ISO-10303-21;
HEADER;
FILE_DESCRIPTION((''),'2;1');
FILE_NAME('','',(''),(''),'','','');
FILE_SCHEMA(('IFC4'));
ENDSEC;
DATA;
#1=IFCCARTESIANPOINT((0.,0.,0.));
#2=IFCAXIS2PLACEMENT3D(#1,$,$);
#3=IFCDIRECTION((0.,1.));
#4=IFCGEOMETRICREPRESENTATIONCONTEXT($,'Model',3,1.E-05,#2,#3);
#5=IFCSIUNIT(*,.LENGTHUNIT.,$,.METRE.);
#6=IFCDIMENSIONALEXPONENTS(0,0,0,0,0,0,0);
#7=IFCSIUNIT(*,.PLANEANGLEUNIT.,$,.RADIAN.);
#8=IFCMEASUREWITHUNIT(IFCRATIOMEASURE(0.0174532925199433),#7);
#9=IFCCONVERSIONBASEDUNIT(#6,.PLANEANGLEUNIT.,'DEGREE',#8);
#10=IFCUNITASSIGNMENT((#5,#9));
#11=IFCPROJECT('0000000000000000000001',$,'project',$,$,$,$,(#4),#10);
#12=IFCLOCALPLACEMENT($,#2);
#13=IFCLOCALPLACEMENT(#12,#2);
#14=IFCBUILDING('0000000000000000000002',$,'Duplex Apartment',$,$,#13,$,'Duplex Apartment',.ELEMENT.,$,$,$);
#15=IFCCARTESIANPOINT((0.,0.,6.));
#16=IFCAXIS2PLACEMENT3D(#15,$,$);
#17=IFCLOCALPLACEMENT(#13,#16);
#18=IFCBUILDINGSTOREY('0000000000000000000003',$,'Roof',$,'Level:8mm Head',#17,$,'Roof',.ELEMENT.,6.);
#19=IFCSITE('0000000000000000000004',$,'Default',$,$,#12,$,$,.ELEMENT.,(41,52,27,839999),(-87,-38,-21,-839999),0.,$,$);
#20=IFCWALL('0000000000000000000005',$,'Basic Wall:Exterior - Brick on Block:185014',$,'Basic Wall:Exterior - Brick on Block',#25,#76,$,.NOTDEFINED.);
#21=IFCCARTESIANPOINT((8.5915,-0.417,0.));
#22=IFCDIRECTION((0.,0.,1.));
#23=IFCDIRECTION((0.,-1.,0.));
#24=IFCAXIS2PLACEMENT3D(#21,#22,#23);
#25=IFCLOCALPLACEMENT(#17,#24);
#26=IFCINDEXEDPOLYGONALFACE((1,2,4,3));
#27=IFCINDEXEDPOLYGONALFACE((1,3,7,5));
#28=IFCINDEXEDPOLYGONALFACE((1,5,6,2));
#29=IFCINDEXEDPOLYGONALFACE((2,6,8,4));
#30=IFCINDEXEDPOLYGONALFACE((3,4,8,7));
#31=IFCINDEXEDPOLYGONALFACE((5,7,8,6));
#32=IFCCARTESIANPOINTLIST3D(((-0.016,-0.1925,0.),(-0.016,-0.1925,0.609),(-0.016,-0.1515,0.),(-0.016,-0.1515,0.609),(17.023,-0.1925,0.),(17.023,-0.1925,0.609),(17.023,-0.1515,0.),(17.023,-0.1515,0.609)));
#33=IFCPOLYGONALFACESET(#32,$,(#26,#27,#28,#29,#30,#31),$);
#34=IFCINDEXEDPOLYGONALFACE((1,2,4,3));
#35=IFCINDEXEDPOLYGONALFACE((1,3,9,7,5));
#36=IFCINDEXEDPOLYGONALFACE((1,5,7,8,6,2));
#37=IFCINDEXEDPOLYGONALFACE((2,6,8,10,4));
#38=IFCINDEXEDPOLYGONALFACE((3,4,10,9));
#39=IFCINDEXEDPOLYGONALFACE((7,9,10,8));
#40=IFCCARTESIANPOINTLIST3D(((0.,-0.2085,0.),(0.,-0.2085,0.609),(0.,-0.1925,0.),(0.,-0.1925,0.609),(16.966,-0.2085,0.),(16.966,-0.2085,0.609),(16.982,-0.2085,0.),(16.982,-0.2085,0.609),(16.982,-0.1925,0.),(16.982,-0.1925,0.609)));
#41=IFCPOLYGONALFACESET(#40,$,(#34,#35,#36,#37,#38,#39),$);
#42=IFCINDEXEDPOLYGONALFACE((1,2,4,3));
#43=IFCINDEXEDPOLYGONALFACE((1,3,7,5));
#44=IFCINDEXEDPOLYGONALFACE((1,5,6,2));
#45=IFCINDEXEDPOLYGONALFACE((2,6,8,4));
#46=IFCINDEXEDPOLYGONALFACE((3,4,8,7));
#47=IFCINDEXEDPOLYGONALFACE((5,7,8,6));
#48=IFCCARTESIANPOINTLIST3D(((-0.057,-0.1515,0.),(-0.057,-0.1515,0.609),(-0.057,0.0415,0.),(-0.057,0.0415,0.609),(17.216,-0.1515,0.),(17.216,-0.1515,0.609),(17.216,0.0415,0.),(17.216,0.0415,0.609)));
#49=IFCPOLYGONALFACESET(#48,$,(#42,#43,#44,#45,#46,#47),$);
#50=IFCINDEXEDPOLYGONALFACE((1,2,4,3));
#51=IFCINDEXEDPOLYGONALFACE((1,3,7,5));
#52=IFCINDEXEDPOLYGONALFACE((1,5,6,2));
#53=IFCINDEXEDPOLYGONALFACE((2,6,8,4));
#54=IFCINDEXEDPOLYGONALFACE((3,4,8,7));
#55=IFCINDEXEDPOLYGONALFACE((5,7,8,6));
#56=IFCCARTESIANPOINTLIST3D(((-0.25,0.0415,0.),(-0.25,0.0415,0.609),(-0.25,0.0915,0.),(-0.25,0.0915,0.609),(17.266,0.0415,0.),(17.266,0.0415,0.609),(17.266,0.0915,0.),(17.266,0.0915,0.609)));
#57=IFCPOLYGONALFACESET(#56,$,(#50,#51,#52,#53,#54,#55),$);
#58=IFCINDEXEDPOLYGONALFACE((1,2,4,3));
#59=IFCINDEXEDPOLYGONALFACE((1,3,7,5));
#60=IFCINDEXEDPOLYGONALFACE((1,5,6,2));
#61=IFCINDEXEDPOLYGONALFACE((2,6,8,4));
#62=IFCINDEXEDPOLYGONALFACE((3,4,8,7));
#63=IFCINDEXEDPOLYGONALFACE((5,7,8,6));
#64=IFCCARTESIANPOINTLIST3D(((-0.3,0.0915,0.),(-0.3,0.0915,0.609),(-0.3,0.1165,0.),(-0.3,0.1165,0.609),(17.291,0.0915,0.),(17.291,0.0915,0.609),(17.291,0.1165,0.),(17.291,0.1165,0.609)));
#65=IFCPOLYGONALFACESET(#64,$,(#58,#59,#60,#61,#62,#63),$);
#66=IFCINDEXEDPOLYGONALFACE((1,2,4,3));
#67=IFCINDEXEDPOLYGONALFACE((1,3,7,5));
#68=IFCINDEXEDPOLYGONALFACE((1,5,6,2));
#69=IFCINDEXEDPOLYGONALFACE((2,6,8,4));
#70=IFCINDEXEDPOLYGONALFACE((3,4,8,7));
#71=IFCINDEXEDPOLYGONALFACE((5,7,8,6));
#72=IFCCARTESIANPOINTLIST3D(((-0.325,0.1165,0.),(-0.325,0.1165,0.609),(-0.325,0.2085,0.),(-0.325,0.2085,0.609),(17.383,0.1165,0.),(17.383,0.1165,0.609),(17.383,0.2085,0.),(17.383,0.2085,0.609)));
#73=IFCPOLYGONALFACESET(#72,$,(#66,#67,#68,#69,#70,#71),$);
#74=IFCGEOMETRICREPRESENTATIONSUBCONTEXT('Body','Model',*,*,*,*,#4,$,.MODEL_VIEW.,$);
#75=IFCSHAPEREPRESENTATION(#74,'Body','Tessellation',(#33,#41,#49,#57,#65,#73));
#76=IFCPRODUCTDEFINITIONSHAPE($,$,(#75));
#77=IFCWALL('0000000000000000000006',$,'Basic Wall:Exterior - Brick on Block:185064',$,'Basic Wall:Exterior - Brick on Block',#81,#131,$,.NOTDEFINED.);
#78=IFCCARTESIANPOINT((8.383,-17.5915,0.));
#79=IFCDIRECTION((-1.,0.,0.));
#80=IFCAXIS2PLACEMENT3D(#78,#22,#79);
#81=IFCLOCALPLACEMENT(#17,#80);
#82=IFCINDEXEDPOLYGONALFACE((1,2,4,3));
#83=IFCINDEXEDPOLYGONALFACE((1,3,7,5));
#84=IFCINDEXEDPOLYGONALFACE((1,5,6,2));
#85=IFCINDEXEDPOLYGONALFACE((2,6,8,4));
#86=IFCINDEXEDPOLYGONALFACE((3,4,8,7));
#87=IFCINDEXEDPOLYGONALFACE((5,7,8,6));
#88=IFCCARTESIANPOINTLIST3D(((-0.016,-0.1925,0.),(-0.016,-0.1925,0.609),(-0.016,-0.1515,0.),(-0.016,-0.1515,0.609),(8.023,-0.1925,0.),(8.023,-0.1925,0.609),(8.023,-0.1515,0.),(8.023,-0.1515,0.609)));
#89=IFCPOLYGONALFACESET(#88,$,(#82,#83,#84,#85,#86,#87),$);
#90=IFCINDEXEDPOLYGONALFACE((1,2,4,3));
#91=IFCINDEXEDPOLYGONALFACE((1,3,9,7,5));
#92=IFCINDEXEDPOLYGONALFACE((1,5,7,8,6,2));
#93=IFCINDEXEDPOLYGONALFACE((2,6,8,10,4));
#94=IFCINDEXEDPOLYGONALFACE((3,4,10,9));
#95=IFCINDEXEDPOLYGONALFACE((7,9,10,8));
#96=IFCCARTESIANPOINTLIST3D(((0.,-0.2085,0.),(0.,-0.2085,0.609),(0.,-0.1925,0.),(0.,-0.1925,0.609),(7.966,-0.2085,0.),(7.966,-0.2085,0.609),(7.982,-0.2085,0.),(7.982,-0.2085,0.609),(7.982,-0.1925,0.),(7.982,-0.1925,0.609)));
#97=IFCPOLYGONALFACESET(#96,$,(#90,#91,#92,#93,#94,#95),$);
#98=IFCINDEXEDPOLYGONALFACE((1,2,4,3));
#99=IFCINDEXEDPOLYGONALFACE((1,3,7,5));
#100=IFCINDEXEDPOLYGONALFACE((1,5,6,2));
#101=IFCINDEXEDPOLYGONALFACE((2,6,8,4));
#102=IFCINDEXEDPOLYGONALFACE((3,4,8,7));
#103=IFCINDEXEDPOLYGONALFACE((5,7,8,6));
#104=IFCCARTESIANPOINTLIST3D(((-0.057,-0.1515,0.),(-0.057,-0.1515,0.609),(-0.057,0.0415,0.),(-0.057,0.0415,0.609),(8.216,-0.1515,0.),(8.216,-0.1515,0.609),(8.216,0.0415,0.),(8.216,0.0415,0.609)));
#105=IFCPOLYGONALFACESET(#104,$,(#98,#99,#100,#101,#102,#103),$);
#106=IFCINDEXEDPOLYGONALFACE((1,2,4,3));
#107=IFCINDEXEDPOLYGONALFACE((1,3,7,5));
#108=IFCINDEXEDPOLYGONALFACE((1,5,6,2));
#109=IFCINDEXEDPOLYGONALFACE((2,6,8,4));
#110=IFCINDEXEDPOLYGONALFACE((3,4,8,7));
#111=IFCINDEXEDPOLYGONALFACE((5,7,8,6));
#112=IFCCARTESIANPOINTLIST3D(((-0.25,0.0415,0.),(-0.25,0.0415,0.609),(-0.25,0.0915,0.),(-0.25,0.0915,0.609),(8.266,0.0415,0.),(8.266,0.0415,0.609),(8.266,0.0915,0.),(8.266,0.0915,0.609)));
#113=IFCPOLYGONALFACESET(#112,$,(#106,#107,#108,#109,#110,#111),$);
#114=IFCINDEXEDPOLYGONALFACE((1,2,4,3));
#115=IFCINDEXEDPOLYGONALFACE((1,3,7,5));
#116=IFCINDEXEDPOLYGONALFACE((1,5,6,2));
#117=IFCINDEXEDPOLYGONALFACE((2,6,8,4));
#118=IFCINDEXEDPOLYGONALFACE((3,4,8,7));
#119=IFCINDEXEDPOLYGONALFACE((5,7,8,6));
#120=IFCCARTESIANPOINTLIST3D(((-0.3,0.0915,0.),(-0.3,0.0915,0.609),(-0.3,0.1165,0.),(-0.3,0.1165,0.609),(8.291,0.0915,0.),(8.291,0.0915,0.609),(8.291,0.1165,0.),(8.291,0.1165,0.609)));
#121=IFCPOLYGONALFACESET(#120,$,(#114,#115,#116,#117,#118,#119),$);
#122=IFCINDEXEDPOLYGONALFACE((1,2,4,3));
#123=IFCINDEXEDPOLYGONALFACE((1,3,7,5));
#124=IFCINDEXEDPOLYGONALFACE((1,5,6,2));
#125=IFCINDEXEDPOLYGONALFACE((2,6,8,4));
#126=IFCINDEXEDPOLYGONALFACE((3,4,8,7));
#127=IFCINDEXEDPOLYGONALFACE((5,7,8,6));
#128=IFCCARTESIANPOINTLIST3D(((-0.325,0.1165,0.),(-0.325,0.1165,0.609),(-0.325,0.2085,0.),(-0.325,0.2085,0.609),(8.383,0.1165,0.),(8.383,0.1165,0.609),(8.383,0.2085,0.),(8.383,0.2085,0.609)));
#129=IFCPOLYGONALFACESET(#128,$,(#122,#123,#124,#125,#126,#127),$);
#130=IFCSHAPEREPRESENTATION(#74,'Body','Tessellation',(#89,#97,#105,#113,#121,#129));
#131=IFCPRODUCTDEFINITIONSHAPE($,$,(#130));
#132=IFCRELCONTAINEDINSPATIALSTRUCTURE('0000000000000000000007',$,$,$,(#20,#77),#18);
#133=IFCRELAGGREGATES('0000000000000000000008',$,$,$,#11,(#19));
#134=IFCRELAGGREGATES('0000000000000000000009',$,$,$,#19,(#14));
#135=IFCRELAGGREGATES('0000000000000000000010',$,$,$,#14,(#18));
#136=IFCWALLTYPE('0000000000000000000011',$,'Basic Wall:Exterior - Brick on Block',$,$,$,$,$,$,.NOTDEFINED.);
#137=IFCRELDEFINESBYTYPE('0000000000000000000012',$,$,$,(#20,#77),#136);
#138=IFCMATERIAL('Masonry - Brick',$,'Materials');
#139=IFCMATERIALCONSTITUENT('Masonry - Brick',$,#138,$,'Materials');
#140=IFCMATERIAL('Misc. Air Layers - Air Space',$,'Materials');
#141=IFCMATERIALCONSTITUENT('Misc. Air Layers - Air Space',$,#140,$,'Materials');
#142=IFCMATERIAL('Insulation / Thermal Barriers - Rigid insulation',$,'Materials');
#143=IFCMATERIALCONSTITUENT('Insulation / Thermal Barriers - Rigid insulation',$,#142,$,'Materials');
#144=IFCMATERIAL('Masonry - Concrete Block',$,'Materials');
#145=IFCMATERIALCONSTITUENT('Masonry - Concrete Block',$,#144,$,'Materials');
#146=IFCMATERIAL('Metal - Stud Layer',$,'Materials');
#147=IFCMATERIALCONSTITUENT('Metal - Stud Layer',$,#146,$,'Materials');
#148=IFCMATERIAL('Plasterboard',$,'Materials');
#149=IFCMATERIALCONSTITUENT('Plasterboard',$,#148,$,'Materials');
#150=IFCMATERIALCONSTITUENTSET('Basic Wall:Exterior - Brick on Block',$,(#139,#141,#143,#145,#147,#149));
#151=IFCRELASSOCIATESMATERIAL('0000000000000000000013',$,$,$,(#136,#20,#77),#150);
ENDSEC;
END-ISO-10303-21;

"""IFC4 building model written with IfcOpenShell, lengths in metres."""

from ifc_helpers import new_model, entity, si_unit, converted_unit, direction, frame, origin, place, context, subcontext, project, spatial, indexed_curve, outline, extrude, material, constituent, constituent_set, type_object, element, save


model = new_model("IFC4")

# Units and contexts
model_context = context("Model", 3, precision=1e-05, world=origin(), true_north=direction((0.0, 1.0)))
body_context = subcontext(model_context, "Body", "Model", "MODEL_VIEW")
ifc_project = project(units=[si_unit("LENGTHUNIT", "METRE"), converted_unit("PLANEANGLEUNIT", "DEGREE", entity("IfcRatioMeasure", 0.0174532925199433), si_unit("PLANEANGLEUNIT", "RADIAN"), dimensions=[0, 0, 0, 0, 0, 0, 0])], contexts=[model_context])

# Site, building, storey
site_placement = place(None, origin())
site = spatial("IfcSite", under=ifc_project, at=site_placement, Name="Default", CompositionType="ELEMENT", RefLatitude=(41, 52, 27, 839999), RefLongitude=(-87, -38, -21, -839999), RefElevation=0.0)
building_placement = place(site_placement, origin())
building = spatial("IfcBuilding", under=site, at=building_placement, Name="Duplex Apartment", LongName="Duplex Apartment", CompositionType="ELEMENT")
storey_placement = place(building_placement, frame((0.0, 0.0, 6.0)))
storey = spatial("IfcBuildingStorey", under=building, at=storey_placement, Name="Roof", ObjectType="Level:8mm Head", LongName="Roof", CompositionType="ELEMENT", Elevation=6.0)

# Shared definitions
ifc_material_1 = material(Name="Insulation / Thermal Barriers - Rigid insulation", Category="Materials")

# Walls
ifc_material_2 = material(Name="Masonry - Brick", Category="Materials")
ifc_constituent_1 = constituent(ifc_material_2, Name="Masonry - Brick", Category="Materials")
ifc_material_3 = material(Name="Misc. Air Layers - Air Space", Category="Materials")
ifc_constituent_2 = constituent(ifc_material_3, Name="Misc. Air Layers - Air Space", Category="Materials")
ifc_constituent_3 = constituent(ifc_material_1, Name="Insulation / Thermal Barriers - Rigid insulation", Category="Materials")
ifc_material_4 = material(Name="Masonry - Concrete Block", Category="Materials")
ifc_constituent_4 = constituent(ifc_material_4, Name="Masonry - Concrete Block", Category="Materials")
ifc_material_5 = material(Name="Metal - Stud Layer", Category="Materials")
ifc_constituent_5 = constituent(ifc_material_5, Name="Metal - Stud Layer", Category="Materials")
ifc_material_6 = material(Name="Plasterboard", Category="Materials")
ifc_constituent_6 = constituent(ifc_material_6, Name="Plasterboard", Category="Materials")
ifc_constituent_set_1 = constituent_set(constituents=[ifc_constituent_1, ifc_constituent_2, ifc_constituent_3, ifc_constituent_4, ifc_constituent_5, ifc_constituent_6], Name="Basic Wall:Exterior - Brick on Block")
wall_type = type_object("IfcWallType", Name="Basic Wall:Exterior - Brick on Block", PredefinedType="NOTDEFINED", material=ifc_constituent_set_1)
wall_1_placement = place(storey_placement, frame((8.5915, -0.417, 0.0), z_axis=(0.0, 0.0, 1.0), x_axis=(0.0, -1.0, 0.0)))
element("IfcWall", 1, at=wall_1_placement, inside=storey, type_object=wall_type, material=ifc_constituent_set_1, Name="Basic Wall:Exterior - Brick on Block:185014", ObjectType="Basic Wall:Exterior - Brick on Block", PredefinedType="NOTDEFINED", context=body_context, shape_type="SweptSolid", body=[
    extrude(outline(indexed_curve([(-8.5195, -0.0205), (8.5195, -0.0205), (8.5195, 0.0205), (-8.5195, 0.0205), (-8.5195, -0.0205)], self_intersect=False)), frame((8.5035, -0.172, 0.0)), (0.0, 0.0, 1.0), 0.609),
    extrude(outline(indexed_curve([(6.78, -0.0064), (6.796, -0.0064), (6.796, 0.0096), (-10.186, 0.0096), (-10.186, -0.0064), (6.78, -0.0064)], self_intersect=False)), frame((10.186, -0.2021, 0.0)), (0.0, 0.0, 1.0), 0.609),
    extrude(outline(indexed_curve([(-8.6365, -0.0965), (8.6365, -0.0965), (8.6365, 0.0965), (-8.6365, 0.0965), (-8.6365, -0.0965)], self_intersect=False)), frame((8.5795, -0.055, 0.0)), (0.0, 0.0, 1.0), 0.609),
    extrude(outline(indexed_curve([(-8.758, -0.025), (8.758, -0.025), (8.758, 0.025), (-8.758, 0.025), (-8.758, -0.025)], self_intersect=False)), frame((8.508, 0.0665, 0.0)), (0.0, 0.0, 1.0), 0.609),
    extrude(outline(indexed_curve([(-8.7955, -0.0125), (8.7955, -0.0125), (8.7955, 0.0125), (-8.7955, 0.0125), (-8.7955, -0.0125)], self_intersect=False)), frame((8.4955, 0.104, 0.0)), (0.0, 0.0, 1.0), 0.609),
    extrude(outline(indexed_curve([(-0.046, -8.854), (0.046, -8.854), (0.046, 8.854), (-0.046, 8.854), (-0.046, -8.854)], self_intersect=False)), frame((8.529, 0.1625, 0.0), z_axis=(0.0, 0.0, 1.0), x_axis=(0.0, -1.0, 0.0)), (0.0, 0.0, 1.0), 0.609),
])
wall_2_placement = place(storey_placement, frame((8.383, -17.5915, 0.0), z_axis=(0.0, 0.0, 1.0), x_axis=(-1.0, 0.0, 0.0)))
element("IfcWall", 2, at=wall_2_placement, inside=storey, type_object=wall_type, material=ifc_constituent_set_1, Name="Basic Wall:Exterior - Brick on Block:185064", ObjectType="Basic Wall:Exterior - Brick on Block", PredefinedType="NOTDEFINED", context=body_context, shape_type="SweptSolid", body=[
    extrude(outline(indexed_curve([(-4.0195, -0.0205), (4.0195, -0.0205), (4.0195, 0.0205), (-4.0195, 0.0205), (-4.0195, -0.0205)], self_intersect=False)), frame((4.0035, -0.172, 0.0)), (0.0, 0.0, 1.0), 0.609),
    extrude(outline(indexed_curve([(3.18, -0.0064), (3.196, -0.0064), (3.196, 0.0096), (-4.786, 0.0096), (-4.786, -0.0064), (3.18, -0.0064)], self_intersect=False)), frame((4.786, -0.2021, 0.0)), (0.0, 0.0, 1.0), 0.609),
    extrude(outline(indexed_curve([(-4.1365, -0.0965), (4.1365, -0.0965), (4.1365, 0.0965), (-4.1365, 0.0965), (-4.1365, -0.0965)], self_intersect=False)), frame((4.0795, -0.055, 0.0)), (0.0, 0.0, 1.0), 0.609),
    extrude(outline(indexed_curve([(-4.258, -0.025), (4.258, -0.025), (4.258, 0.025), (-4.258, 0.025), (-4.258, -0.025)], self_intersect=False)), frame((4.008, 0.0665, 0.0)), (0.0, 0.0, 1.0), 0.609),
    extrude(outline(indexed_curve([(-4.2955, -0.0125), (4.2955, -0.0125), (4.2955, 0.0125), (-4.2955, 0.0125), (-4.2955, -0.0125)], self_intersect=False)), frame((3.9955, 0.104, 0.0)), (0.0, 0.0, 1.0), 0.609),
    extrude(outline(indexed_curve([(-0.046, -4.354), (0.046, -4.354), (0.046, 4.354), (-0.046, 4.354), (-0.046, -4.354)], self_intersect=False)), frame((4.029, 0.1625, 0.0), z_axis=(0.0, 0.0, 1.0), x_axis=(0.0, -1.0, 0.0)), (0.0, 0.0, 1.0), 0.609),
])

save(model, "model.ifc")
